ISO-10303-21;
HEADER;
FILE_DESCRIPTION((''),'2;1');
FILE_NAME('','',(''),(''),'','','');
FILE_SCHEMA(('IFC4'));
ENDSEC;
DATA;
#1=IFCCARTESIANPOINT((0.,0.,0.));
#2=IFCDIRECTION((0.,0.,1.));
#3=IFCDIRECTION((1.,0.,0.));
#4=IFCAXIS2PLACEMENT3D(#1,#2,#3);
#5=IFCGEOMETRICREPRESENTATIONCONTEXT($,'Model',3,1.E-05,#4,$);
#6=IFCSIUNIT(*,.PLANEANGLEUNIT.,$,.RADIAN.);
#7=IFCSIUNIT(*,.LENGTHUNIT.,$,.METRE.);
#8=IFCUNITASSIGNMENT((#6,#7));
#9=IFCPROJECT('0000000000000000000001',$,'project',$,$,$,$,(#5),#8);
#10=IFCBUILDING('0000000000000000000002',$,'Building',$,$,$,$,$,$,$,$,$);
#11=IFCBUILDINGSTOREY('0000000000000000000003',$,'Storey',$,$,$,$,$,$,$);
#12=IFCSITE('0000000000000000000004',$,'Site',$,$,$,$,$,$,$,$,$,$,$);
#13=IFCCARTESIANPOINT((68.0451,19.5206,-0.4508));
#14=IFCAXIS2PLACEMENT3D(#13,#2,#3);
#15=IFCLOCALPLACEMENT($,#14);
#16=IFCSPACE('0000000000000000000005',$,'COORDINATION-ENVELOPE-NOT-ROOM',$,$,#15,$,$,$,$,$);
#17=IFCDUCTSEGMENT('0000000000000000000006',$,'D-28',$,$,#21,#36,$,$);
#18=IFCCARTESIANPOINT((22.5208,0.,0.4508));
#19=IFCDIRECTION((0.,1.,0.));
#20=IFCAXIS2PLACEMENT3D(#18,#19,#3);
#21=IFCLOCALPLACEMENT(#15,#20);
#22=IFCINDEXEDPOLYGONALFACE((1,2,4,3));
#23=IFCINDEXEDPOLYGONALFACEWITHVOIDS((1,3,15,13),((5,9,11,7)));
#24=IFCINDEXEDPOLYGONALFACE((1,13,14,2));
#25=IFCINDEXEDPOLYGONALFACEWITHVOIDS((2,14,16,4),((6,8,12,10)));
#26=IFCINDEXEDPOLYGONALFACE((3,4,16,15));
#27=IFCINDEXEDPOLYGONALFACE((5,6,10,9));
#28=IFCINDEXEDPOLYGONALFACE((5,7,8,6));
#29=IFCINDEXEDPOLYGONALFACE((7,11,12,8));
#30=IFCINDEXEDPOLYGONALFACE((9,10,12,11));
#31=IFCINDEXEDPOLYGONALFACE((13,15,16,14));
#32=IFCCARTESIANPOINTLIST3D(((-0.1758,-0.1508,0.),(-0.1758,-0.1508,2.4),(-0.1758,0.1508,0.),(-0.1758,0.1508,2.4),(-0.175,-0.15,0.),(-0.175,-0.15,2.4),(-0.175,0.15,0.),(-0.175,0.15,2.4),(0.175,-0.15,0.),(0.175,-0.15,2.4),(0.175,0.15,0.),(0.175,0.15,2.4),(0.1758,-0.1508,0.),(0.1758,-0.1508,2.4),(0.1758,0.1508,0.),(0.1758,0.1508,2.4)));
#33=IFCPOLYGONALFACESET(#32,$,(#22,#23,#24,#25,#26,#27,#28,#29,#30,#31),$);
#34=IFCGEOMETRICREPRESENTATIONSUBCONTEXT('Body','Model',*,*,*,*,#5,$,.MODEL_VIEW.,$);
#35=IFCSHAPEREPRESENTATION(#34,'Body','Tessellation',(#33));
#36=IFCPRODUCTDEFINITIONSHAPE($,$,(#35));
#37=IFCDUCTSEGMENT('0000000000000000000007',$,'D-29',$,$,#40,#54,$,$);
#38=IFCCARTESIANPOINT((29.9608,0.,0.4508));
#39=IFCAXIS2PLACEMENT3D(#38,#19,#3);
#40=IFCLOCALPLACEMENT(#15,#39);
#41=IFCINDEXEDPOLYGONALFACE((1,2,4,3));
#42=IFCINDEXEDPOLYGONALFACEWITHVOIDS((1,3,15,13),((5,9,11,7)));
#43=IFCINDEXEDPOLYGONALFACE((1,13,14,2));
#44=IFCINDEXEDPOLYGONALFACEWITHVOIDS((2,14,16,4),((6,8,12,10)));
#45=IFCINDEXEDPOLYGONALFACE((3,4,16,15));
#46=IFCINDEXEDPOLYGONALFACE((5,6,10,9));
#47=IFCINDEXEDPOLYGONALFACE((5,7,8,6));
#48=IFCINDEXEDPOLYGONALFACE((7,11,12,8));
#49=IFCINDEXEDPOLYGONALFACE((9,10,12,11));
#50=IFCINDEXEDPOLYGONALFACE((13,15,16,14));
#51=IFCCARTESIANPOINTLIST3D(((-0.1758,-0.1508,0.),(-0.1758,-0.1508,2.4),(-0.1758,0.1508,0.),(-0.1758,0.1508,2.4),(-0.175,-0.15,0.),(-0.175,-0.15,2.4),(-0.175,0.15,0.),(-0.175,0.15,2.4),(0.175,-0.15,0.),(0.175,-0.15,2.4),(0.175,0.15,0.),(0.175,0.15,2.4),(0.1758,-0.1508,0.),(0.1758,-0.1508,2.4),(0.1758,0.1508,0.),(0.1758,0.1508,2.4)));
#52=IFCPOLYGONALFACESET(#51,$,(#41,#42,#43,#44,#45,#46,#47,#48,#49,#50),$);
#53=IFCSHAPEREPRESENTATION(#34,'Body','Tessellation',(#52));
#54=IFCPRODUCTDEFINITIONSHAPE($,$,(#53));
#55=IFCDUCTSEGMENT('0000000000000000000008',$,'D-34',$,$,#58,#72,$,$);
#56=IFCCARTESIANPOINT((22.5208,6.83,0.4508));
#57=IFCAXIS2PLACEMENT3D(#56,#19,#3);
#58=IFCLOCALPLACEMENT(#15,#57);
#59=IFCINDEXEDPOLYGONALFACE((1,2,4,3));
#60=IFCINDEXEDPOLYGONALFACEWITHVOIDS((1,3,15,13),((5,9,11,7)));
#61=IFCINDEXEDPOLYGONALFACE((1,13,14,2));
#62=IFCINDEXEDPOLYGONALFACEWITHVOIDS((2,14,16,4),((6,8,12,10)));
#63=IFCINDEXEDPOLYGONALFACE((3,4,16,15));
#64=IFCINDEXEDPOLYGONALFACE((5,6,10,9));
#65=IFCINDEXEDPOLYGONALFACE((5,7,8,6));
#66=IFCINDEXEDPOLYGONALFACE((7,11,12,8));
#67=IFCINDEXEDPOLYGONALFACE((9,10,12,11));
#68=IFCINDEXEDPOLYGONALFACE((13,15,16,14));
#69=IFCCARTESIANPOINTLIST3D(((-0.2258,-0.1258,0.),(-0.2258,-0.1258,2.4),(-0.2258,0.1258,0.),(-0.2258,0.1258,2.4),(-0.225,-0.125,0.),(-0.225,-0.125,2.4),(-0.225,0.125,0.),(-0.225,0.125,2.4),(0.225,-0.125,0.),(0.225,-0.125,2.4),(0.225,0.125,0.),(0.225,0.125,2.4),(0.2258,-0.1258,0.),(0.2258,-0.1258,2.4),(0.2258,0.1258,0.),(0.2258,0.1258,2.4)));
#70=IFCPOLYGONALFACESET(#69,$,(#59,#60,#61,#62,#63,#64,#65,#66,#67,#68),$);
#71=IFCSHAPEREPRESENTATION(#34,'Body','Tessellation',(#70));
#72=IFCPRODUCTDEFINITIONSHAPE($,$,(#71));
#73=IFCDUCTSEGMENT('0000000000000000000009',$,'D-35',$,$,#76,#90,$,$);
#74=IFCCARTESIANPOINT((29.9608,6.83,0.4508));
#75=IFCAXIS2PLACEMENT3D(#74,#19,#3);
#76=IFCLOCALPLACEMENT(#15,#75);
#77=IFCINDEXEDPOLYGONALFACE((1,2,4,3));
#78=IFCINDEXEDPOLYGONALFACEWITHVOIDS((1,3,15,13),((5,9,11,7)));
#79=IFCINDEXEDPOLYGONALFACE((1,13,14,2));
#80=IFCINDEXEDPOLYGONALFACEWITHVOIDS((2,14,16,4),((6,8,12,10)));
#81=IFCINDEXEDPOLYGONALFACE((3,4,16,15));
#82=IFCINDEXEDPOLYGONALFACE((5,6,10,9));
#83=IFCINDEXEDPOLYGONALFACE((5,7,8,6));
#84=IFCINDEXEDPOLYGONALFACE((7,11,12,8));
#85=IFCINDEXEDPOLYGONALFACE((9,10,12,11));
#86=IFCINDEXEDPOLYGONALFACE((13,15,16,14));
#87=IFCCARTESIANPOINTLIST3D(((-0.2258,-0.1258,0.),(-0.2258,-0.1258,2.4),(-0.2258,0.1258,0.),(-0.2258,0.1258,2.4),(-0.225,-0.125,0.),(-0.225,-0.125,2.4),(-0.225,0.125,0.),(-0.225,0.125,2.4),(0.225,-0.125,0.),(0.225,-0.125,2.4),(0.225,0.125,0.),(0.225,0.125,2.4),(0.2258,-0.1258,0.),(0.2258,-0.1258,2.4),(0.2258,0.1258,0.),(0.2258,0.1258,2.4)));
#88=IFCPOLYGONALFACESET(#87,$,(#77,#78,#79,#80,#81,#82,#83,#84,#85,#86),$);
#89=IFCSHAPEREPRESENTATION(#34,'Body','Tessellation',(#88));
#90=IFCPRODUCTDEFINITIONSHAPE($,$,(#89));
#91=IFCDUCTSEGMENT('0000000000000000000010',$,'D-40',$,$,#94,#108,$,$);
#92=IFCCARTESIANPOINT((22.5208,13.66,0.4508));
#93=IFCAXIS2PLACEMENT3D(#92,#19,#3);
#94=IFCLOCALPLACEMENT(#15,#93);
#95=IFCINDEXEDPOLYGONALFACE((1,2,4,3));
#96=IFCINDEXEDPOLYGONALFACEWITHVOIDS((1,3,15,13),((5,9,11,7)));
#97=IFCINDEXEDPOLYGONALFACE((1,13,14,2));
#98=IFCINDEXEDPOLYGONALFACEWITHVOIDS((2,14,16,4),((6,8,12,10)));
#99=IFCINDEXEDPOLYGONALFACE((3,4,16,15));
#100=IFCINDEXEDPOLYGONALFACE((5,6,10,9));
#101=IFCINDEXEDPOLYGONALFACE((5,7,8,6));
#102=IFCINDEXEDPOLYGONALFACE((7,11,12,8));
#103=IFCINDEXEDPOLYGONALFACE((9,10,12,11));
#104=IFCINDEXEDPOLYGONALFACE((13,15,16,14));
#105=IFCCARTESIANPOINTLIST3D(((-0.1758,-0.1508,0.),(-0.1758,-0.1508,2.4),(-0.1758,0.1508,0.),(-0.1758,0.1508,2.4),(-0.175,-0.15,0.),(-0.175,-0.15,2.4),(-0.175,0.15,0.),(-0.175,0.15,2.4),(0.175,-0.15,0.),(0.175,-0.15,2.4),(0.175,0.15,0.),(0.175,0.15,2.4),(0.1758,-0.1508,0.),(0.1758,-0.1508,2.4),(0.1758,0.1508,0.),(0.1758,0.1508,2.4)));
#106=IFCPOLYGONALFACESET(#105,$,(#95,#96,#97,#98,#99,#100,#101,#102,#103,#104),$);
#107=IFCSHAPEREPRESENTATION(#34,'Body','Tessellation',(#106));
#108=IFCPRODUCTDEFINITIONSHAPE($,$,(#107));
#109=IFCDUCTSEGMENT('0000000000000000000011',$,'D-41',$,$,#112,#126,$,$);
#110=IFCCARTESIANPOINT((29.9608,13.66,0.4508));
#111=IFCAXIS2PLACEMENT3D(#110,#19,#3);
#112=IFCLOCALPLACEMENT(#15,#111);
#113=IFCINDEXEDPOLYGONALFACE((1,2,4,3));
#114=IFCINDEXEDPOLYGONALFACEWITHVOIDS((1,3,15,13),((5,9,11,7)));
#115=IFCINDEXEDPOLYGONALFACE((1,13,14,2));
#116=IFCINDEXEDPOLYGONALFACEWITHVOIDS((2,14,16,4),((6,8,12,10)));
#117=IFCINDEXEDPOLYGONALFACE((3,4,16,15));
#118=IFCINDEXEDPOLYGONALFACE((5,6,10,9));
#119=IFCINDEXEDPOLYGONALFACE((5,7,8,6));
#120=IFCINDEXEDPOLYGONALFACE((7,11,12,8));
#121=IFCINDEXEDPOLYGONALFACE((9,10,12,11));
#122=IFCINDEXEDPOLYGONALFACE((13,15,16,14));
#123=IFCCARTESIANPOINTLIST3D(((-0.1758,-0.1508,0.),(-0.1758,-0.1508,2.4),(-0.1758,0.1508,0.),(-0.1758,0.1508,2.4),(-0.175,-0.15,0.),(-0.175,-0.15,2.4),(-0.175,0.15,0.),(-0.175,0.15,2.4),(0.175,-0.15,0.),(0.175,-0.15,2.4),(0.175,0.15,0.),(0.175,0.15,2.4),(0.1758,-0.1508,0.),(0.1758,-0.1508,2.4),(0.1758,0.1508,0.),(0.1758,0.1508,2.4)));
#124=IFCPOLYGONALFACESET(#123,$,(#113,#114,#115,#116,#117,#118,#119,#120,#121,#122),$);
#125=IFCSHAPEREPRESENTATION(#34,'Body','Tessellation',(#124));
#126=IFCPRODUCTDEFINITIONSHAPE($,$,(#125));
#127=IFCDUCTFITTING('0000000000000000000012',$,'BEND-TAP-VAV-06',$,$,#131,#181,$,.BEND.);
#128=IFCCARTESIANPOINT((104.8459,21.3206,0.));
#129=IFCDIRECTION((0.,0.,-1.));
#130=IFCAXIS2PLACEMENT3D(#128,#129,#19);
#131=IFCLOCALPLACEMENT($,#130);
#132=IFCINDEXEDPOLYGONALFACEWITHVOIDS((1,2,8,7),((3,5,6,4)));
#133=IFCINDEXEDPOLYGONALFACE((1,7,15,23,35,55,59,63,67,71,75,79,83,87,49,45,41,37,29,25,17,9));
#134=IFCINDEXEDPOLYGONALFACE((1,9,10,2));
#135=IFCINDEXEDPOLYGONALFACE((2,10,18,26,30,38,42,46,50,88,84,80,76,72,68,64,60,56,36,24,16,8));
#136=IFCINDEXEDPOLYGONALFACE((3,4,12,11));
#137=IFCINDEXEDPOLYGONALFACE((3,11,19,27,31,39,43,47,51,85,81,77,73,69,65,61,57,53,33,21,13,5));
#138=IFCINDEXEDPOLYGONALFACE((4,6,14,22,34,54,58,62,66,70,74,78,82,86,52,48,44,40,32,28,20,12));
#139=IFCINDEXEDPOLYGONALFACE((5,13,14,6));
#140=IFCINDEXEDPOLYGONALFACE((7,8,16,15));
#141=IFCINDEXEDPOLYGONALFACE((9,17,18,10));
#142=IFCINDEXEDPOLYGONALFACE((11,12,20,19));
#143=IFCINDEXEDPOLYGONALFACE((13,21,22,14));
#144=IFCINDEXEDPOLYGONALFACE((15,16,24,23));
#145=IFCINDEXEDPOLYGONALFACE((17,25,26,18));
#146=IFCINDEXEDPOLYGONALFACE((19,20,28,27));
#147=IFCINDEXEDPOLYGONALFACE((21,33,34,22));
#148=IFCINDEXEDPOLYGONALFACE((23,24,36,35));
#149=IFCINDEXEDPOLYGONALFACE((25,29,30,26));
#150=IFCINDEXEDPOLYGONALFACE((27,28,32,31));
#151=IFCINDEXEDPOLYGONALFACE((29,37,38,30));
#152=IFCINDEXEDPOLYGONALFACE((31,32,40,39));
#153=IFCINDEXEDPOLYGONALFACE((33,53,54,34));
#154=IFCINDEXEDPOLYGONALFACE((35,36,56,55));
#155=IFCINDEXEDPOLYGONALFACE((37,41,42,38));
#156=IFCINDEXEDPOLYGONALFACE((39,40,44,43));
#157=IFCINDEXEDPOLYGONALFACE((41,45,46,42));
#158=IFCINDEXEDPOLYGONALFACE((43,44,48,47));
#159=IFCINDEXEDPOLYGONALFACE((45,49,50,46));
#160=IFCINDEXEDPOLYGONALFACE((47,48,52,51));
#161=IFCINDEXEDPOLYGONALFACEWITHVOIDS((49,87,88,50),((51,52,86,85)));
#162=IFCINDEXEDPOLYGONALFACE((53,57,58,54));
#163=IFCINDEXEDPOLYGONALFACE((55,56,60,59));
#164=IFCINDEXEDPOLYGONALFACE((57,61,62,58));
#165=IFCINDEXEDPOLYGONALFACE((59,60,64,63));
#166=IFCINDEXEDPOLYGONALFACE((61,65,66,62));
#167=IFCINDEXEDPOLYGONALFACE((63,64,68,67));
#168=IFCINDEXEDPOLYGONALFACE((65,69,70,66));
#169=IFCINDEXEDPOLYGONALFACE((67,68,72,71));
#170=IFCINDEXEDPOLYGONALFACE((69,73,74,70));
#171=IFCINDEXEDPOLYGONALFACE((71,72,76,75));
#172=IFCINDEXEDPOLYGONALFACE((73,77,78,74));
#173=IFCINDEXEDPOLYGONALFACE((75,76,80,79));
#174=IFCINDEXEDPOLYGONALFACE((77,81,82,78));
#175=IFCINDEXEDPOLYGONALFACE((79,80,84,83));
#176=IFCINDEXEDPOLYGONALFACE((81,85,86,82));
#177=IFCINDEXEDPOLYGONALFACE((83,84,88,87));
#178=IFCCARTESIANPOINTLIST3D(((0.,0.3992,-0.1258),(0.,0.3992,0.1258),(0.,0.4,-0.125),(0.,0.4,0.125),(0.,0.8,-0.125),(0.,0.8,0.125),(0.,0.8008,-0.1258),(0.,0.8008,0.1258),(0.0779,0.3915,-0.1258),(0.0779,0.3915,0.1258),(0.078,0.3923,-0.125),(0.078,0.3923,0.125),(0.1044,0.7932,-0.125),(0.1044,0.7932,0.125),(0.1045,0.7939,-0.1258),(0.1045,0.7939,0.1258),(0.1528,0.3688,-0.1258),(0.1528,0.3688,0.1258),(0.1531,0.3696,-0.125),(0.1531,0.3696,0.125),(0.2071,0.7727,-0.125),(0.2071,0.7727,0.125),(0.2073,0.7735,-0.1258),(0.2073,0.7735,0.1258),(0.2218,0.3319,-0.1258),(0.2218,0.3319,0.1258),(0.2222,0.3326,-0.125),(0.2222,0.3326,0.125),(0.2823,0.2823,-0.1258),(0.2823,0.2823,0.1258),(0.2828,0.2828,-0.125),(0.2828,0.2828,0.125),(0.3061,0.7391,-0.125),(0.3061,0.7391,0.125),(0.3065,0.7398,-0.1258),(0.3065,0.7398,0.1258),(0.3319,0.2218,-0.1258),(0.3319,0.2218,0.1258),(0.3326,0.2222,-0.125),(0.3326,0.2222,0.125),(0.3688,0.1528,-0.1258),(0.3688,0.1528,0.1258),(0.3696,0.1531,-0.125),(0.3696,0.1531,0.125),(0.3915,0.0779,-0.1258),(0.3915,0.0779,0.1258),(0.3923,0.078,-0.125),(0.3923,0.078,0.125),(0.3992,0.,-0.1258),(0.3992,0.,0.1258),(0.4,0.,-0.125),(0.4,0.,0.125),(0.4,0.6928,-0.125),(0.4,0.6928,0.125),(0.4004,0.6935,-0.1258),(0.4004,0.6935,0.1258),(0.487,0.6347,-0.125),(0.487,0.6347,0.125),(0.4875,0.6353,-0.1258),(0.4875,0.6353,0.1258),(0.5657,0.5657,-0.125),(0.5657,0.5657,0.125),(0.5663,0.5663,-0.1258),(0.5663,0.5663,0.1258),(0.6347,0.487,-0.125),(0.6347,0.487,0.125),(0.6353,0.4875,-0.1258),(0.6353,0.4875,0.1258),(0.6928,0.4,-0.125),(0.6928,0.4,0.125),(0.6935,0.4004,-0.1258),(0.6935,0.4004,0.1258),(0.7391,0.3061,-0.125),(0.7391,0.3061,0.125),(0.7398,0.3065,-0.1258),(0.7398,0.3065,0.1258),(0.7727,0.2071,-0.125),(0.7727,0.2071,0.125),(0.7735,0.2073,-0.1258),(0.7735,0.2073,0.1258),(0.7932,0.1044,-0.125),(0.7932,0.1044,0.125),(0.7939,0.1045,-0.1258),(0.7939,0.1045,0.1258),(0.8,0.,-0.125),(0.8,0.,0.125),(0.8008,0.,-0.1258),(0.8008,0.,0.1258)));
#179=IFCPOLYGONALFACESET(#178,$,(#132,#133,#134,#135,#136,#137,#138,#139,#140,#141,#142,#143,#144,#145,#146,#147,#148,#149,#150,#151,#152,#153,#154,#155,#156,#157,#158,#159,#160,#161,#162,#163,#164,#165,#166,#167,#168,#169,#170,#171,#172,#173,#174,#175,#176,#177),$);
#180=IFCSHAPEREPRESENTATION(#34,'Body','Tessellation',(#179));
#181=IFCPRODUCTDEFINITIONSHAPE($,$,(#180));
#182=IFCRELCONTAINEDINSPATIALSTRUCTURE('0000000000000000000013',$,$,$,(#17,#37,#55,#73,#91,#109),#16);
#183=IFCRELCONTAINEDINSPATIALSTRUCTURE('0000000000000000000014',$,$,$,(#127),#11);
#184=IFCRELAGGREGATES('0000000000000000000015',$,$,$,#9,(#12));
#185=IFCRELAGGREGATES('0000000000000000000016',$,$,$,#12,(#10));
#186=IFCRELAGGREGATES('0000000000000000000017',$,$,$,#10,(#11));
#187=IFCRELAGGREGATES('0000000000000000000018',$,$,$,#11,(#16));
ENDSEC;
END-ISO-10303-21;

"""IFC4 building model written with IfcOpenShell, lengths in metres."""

from ifc_helpers import new_model, entity, si_unit, frame, origin, origin_with_axes, place, context, subcontext, project, spatial, hollow_rectangle, extrude, element, save


model = new_model("IFC4")

# Units and contexts
model_context = context("Model", 3, precision=1e-05, world=origin_with_axes())
body_context = subcontext(model_context, "Body", "Model", "MODEL_VIEW")
ifc_project = project(units=[si_unit("PLANEANGLEUNIT", "RADIAN"), si_unit("LENGTHUNIT", "METRE")], contexts=[model_context])

# Site, building, storey, space
site = spatial("IfcSite", under=ifc_project, Name="Site")
building = spatial("IfcBuilding", under=site, Name="Building")
storey = spatial("IfcBuildingStorey", under=building, Name="Storey")
space_placement = place(None, frame((68.0451, 19.5206, -0.4508), z_axis=(0.0, 0.0, 1.0), x_axis=(1.0, 0.0, 0.0)))
space = spatial("IfcSpace", under=storey, at=space_placement, Name="COORDINATION-ENVELOPE-NOT-ROOM")

# Duct segments
for number, where, z_axis, x_axis, name in (
    (1, (22.5208, 0.0, 0.4508), (0.0, 1.0, 0.0), (1.0, 0.0, 0.0), "D-28"),
    (2, (29.9608, 0.0, 0.4508), (0.0, 1.0, 0.0), (1.0, 0.0, 0.0), "D-29"),
):
    element("IfcDuctSegment", number, at=place(space_placement, frame(where, z_axis=z_axis, x_axis=x_axis)), inside=space, Name=name, context=body_context, shape_type="SweptSolid", body=[
        extrude(hollow_rectangle(XDim=0.3516, YDim=0.3016, WallThickness=0.0008), origin(), (0.0, 0.0, 1.0), 2.4),
    ])
for number, where, z_axis, x_axis, name in (
    (3, (22.5208, 6.83, 0.4508), (0.0, 1.0, 0.0), (1.0, 0.0, 0.0), "D-34"),
    (4, (29.9608, 6.83, 0.4508), (0.0, 1.0, 0.0), (1.0, 0.0, 0.0), "D-35"),
):
    element("IfcDuctSegment", number, at=place(space_placement, frame(where, z_axis=z_axis, x_axis=x_axis)), inside=space, Name=name, context=body_context, shape_type="SweptSolid", body=[
        extrude(hollow_rectangle(XDim=0.4516, YDim=0.2516, WallThickness=0.0008), origin(), (0.0, 0.0, 1.0), 2.4),
    ])
for number, where, z_axis, x_axis, name in (
    (5, (22.5208, 13.66, 0.4508), (0.0, 1.0, 0.0), (1.0, 0.0, 0.0), "D-40"),
    (6, (29.9608, 13.66, 0.4508), (0.0, 1.0, 0.0), (1.0, 0.0, 0.0), "D-41"),
):
    element("IfcDuctSegment", number, at=place(space_placement, frame(where, z_axis=z_axis, x_axis=x_axis)), inside=space, Name=name, context=body_context, shape_type="SweptSolid", body=[
        extrude(hollow_rectangle(XDim=0.3516, YDim=0.3016, WallThickness=0.0008), origin(), (0.0, 0.0, 1.0), 2.4),
    ])

# Duct fitting
duct_fitting_1_placement = place(None, frame((104.8459, 21.3206, 0.0), z_axis=(0.0, 0.0, -1.0), x_axis=(0.0, 1.0, 0.0)))
cartesian_point_1 = entity("IfcCartesianPoint", [0.0, 0.0, 0.0])
element("IfcDuctFitting", 7, at=duct_fitting_1_placement, inside=storey, Name="BEND-TAP-VAV-06", PredefinedType="BEND", context=body_context, shape_type="SweptSolid", body=[
    entity("IfcRevolvedAreaSolid", entity("IfcRectangleHollowProfileDef", "AREA", None, entity("IfcAxis2Placement2D", entity("IfcCartesianPoint", [0.6, 0.0])), 0.4016, 0.2516, 0.0008), entity("IfcAxis2Placement3D", cartesian_point_1, entity("IfcDirection", [0.0, -1.0, 0.0]), entity("IfcDirection", [1.0, 0.0, 0.0])), entity("IfcAxis1Placement", cartesian_point_1, entity("IfcDirection", [0.0, 1.0, 0.0])), 1.570796),
])

save(model, "model.ifc")
